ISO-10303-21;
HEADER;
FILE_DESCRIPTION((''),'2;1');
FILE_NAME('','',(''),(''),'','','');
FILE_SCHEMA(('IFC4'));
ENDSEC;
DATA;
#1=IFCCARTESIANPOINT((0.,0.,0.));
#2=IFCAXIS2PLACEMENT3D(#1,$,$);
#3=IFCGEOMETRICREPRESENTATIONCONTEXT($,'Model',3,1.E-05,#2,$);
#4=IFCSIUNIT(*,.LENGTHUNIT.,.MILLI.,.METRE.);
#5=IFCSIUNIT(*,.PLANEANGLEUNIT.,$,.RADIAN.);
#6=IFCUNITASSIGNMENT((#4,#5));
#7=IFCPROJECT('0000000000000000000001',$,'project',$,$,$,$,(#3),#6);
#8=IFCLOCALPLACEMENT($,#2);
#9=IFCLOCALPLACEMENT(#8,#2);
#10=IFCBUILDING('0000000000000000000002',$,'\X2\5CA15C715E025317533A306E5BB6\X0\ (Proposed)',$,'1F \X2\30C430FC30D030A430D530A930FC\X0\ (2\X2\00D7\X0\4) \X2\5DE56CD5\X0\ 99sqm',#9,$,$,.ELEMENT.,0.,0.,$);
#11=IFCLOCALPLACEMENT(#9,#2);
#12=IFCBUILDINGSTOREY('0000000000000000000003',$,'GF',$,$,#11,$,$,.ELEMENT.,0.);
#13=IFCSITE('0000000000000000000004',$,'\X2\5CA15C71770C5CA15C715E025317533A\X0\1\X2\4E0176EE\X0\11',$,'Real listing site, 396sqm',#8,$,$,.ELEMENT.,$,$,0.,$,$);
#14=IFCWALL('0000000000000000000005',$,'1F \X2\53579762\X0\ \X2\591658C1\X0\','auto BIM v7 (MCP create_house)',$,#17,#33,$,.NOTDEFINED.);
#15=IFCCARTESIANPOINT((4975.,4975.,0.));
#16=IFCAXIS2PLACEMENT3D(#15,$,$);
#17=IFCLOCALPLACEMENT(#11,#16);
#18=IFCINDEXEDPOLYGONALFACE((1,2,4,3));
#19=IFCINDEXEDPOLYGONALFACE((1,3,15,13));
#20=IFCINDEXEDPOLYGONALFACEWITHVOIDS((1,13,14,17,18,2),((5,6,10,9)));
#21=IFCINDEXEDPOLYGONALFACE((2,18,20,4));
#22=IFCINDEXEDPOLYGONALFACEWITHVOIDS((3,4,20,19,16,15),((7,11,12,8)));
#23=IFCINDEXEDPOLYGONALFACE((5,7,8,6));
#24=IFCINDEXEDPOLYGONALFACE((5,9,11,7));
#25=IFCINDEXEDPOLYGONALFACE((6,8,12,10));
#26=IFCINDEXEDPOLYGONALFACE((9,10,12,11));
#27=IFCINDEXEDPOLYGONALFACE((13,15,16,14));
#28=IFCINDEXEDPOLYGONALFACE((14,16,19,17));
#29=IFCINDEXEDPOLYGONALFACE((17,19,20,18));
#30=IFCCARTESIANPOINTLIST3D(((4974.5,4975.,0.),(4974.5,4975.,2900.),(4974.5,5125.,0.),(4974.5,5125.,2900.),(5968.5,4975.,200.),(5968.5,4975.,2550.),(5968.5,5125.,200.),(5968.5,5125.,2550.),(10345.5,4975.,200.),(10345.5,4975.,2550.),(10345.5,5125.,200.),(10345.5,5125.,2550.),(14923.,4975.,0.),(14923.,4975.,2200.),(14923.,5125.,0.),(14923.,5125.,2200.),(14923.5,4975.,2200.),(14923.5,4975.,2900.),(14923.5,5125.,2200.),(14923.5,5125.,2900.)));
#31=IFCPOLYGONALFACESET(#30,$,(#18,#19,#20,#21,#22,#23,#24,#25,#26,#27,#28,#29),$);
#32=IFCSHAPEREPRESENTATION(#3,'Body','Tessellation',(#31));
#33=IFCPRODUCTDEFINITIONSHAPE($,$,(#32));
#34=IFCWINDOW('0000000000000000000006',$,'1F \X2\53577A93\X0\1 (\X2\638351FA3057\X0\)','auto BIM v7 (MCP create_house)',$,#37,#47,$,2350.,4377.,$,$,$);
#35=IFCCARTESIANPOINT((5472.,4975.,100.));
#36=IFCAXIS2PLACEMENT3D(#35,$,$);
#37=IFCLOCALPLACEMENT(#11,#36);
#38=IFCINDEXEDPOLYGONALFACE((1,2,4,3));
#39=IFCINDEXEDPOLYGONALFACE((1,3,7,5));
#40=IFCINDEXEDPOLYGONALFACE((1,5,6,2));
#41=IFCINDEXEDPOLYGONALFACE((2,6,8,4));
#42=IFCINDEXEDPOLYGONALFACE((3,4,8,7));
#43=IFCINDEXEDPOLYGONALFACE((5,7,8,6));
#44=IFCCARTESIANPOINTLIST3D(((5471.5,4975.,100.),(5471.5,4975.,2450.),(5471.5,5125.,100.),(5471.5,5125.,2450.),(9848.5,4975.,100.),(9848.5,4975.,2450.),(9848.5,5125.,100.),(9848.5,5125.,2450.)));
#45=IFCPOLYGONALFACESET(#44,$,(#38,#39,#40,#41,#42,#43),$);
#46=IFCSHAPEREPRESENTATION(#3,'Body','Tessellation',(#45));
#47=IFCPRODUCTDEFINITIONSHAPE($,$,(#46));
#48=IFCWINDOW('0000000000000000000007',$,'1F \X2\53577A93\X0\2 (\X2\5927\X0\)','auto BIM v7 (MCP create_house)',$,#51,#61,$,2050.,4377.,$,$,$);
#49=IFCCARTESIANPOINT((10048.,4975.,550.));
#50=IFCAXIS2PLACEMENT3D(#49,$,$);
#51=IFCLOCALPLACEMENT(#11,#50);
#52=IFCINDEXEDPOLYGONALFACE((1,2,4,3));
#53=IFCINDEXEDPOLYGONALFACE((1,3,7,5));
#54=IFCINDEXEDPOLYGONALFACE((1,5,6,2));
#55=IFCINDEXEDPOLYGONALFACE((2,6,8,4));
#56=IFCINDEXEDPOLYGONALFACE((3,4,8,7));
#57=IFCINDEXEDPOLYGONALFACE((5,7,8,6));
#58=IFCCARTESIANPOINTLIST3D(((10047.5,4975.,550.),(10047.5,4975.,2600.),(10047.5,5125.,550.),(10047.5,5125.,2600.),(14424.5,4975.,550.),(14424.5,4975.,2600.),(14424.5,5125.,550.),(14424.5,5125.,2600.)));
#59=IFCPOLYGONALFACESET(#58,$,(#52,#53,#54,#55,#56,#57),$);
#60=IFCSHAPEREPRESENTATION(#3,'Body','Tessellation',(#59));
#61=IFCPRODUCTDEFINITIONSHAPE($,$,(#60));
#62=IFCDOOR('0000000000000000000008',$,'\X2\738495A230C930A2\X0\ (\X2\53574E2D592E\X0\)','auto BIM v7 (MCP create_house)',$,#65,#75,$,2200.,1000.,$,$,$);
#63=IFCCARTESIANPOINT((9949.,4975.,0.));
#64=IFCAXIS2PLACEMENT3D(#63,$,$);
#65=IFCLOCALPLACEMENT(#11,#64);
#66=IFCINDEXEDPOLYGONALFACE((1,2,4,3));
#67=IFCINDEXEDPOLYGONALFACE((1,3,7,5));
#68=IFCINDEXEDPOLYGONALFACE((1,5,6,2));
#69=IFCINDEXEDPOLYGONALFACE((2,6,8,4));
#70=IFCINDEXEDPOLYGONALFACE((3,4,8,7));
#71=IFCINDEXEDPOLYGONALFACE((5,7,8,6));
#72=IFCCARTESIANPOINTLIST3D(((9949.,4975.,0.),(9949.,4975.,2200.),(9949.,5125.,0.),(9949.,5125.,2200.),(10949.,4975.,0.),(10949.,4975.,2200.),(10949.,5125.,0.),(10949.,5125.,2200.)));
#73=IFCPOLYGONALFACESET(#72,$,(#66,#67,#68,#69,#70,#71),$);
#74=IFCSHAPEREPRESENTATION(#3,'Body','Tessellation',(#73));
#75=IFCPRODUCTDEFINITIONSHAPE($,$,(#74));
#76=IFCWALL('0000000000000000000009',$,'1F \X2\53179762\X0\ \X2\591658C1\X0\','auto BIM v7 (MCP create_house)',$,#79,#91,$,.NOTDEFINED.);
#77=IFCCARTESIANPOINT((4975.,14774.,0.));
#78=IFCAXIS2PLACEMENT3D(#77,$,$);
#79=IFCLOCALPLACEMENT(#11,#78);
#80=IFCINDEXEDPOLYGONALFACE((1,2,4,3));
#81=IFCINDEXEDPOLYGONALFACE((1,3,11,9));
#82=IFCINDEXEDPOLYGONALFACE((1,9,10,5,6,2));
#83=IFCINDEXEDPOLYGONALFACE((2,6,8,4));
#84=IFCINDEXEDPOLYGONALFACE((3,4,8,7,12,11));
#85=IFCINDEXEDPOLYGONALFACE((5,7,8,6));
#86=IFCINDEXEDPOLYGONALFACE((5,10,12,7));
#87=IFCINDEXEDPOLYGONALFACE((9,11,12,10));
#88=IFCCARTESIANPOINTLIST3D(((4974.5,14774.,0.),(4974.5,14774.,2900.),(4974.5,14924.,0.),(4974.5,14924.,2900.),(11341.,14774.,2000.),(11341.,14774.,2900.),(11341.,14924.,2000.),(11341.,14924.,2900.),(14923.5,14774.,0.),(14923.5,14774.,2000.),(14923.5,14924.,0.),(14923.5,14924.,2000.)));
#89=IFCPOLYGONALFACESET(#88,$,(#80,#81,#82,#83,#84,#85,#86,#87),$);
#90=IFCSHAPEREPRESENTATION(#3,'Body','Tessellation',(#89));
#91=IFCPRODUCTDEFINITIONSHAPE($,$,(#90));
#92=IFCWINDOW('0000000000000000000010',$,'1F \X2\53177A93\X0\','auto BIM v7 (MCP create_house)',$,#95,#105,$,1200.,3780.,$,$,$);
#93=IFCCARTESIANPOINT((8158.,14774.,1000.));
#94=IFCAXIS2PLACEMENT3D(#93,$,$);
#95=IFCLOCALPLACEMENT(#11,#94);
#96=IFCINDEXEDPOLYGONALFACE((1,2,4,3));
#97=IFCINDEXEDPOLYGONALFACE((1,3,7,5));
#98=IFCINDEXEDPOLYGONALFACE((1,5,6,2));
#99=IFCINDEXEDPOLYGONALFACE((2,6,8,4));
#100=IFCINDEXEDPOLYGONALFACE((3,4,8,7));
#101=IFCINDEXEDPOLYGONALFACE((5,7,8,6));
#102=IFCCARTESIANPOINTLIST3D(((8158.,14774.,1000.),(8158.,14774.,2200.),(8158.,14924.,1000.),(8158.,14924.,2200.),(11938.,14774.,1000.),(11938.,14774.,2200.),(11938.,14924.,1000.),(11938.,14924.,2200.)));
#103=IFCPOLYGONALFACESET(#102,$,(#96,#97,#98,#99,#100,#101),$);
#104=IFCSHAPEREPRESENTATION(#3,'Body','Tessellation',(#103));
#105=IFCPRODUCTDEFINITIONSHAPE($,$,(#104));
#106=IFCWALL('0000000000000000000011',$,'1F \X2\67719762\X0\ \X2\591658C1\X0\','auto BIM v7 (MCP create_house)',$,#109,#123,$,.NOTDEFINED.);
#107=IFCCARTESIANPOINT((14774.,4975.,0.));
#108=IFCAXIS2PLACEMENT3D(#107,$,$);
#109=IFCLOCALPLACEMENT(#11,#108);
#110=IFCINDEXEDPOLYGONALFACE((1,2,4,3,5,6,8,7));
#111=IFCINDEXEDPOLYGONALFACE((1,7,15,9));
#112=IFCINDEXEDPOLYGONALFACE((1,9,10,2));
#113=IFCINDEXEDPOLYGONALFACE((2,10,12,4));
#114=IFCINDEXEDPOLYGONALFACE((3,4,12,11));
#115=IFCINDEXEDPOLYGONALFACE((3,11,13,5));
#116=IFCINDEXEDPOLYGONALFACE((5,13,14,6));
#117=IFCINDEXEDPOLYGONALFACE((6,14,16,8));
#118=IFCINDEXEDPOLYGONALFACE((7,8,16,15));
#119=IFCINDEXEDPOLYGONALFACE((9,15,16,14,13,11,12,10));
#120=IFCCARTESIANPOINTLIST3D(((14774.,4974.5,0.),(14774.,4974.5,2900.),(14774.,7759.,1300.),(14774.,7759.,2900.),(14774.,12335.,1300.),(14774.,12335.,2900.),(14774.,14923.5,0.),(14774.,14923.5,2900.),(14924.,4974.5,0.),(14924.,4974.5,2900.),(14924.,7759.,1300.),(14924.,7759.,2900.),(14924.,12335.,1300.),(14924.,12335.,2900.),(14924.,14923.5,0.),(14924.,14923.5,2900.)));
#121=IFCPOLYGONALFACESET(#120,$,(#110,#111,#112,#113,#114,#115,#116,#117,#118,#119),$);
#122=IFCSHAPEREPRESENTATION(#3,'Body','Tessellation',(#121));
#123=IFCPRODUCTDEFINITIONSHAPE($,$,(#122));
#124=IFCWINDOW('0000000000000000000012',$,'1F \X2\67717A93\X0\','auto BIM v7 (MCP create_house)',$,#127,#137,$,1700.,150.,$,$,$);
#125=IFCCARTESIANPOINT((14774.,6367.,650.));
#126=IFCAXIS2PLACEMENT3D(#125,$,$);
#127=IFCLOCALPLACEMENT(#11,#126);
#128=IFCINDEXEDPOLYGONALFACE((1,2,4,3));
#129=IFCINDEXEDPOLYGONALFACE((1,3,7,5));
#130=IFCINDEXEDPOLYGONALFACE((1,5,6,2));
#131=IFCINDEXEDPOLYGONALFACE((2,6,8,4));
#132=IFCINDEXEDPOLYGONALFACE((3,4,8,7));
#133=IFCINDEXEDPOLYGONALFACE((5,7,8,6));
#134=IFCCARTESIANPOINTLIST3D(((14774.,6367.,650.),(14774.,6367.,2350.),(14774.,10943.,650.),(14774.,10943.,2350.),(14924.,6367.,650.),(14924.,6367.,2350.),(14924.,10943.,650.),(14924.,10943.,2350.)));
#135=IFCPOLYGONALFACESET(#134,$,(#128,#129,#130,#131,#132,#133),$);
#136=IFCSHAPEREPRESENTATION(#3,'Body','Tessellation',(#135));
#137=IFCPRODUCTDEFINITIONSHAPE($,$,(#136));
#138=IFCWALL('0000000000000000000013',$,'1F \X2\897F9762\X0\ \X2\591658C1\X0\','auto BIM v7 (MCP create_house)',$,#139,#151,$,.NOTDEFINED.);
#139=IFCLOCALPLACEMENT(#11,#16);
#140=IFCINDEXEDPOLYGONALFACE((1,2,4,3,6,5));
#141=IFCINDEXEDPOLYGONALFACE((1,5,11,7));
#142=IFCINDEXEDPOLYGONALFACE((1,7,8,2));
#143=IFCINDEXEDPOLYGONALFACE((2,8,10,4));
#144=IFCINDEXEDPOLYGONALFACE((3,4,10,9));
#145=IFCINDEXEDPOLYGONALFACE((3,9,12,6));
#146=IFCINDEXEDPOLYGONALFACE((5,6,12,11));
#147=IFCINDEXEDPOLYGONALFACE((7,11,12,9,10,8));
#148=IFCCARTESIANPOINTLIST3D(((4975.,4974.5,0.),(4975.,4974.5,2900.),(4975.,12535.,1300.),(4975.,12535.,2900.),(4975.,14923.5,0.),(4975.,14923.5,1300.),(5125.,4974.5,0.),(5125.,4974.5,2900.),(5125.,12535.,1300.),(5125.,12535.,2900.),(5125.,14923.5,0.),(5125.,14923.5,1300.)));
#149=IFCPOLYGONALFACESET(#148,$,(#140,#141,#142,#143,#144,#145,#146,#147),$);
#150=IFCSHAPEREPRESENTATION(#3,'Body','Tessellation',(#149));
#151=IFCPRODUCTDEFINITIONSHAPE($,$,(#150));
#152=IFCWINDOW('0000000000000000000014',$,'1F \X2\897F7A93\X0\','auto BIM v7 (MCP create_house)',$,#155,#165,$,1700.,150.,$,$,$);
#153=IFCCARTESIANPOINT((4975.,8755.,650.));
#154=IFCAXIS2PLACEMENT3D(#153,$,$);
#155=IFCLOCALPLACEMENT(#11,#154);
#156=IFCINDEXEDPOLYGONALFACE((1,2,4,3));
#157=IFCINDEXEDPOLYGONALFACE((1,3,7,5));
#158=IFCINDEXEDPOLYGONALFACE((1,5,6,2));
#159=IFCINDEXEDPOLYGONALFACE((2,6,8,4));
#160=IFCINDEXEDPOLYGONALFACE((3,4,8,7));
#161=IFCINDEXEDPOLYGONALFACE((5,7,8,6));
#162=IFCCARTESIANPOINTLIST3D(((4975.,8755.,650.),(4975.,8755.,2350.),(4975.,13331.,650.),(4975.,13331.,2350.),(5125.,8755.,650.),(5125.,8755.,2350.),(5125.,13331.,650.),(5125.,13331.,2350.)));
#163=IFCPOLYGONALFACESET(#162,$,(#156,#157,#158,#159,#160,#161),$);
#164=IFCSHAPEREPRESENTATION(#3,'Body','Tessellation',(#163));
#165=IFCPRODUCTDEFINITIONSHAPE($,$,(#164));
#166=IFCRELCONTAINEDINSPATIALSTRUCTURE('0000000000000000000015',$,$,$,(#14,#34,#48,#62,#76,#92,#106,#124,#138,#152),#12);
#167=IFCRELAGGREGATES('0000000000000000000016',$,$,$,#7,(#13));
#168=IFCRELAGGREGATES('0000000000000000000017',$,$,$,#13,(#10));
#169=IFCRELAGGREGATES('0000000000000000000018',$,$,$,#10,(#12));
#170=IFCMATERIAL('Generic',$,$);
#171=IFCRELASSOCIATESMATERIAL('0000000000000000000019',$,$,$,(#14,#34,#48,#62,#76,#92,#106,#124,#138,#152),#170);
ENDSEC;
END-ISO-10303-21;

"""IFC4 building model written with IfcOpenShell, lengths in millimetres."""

from ifc_helpers import new_model, si_unit, frame, frame_2d, origin, place, context, project, spatial, rectangle, extrude, material, element, fill, save


model = new_model("IFC4")

# Units and contexts
model_context = context("Model", 3, precision=1e-05, world=origin())
ifc_project = project(units=[si_unit("LENGTHUNIT", "METRE", prefix="MILLI"), si_unit("PLANEANGLEUNIT", "RADIAN")], contexts=[model_context])

# Site, building, storey
site_placement = place(None, origin())
site = spatial("IfcSite", under=ifc_project, at=site_placement, Name="岡山県岡山市北区1丁目11", ObjectType="Real listing site, 396sqm", CompositionType="ELEMENT", RefElevation=0.0)
building_placement = place(site_placement, origin())
building = spatial("IfcBuilding", under=site, at=building_placement, Name="岡山市北区の家 (Proposed)", ObjectType="1F ツーバイフォー (2×4) 工法 99sqm", CompositionType="ELEMENT", ElevationOfRefHeight=0.0, ElevationOfTerrain=0.0)
storey_placement = place(building_placement, origin())
storey = spatial("IfcBuildingStorey", under=building, at=storey_placement, Name="GF", CompositionType="ELEMENT", Elevation=0.0)

# Shared definitions
ifc_material = material(Name="Generic")

# Wall, openings, windows, door
wall_1_placement = place(storey_placement, frame((4975.0, 4975.0, 0.0)))
wall_1 = element("IfcWall", 1, at=wall_1_placement, inside=storey, material=ifc_material, Name="1F 南面 外壁", Description="auto BIM v7 (MCP create_house)", PredefinedType="NOTDEFINED", context=model_context, shape_type="SweptSolid", body=[
    extrude(rectangle(XDim=9949.0, YDim=150.0, at=frame_2d((4974.0, 75.0))), frame((4975.0, 4975.0, 0.0)), (0.0, 0.0, 1.0), 2900.0),
])
opening_1_placement = place(storey_placement, frame((5472.0, 4975.0, 100.0)))
opening_1 = element("IfcOpeningElement", 2, at=opening_1_placement, cuts=wall_1, PredefinedType="NOTDEFINED", context=model_context, shape_type="SweptSolid", body=[
    extrude(rectangle(XDim=4377.0, YDim=150.0, at=frame_2d((2188.0, 75.0))), frame((5472.0, 4975.0, 100.0)), (0.0, 0.0, 1.0), 2350.0),
])
opening_2_placement = place(storey_placement, frame((10048.0, 4975.0, 550.0)))
opening_2 = element("IfcOpeningElement", 3, at=opening_2_placement, cuts=wall_1, PredefinedType="NOTDEFINED", context=model_context, shape_type="SweptSolid", body=[
    extrude(rectangle(XDim=4377.0, YDim=150.0, at=frame_2d((2188.0, 75.0))), frame((10048.0, 4975.0, 550.0)), (0.0, 0.0, 1.0), 2050.0),
])
opening_3_placement = place(storey_placement, frame((9949.0, 4975.0, 0.0)))
opening_3 = element("IfcOpeningElement", 4, at=opening_3_placement, cuts=wall_1, PredefinedType="NOTDEFINED", context=model_context, shape_type="SweptSolid", body=[
    extrude(rectangle(XDim=1000.0, YDim=150.0, at=frame_2d((500.0, 75.0))), frame((9949.0, 4975.0, 0.0)), (0.0, 0.0, 1.0), 2200.0),
])
window_1_placement = place(storey_placement, frame((5472.0, 4975.0, 100.0)))
window_1 = element("IfcWindow", 5, at=window_1_placement, inside=storey, material=ifc_material, Name="1F 南窓1 (掃出し)", Description="auto BIM v7 (MCP create_house)", OverallHeight=2350.0, OverallWidth=4377.0, context=model_context, shape_type="SweptSolid", body=[
    extrude(rectangle(XDim=4377.0, YDim=150.0, at=frame_2d((2188.0, 75.0))), frame((5472.0, 4975.0, 100.0)), (0.0, 0.0, 1.0), 2350.0),
])
fill(opening_1, window_1)
window_2_placement = place(storey_placement, frame((10048.0, 4975.0, 550.0)))
window_2 = element("IfcWindow", 6, at=window_2_placement, inside=storey, material=ifc_material, Name="1F 南窓2 (大)", Description="auto BIM v7 (MCP create_house)", OverallHeight=2050.0, OverallWidth=4377.0, context=model_context, shape_type="SweptSolid", body=[
    extrude(rectangle(XDim=4377.0, YDim=150.0, at=frame_2d((2188.0, 75.0))), frame((10048.0, 4975.0, 550.0)), (0.0, 0.0, 1.0), 2050.0),
])
fill(opening_2, window_2)
door_placement = place(storey_placement, frame((9949.0, 4975.0, 0.0)))
door = element("IfcDoor", 7, at=door_placement, inside=storey, material=ifc_material, Name="玄関ドア (南中央)", Description="auto BIM v7 (MCP create_house)", OverallHeight=2200.0, OverallWidth=1000.0, context=model_context, shape_type="SweptSolid", body=[
    extrude(rectangle(XDim=1000.0, YDim=150.0, at=frame_2d((500.0, 75.0))), frame((9949.0, 4975.0, 0.0)), (0.0, 0.0, 1.0), 2200.0),
])
fill(opening_3, door)

# Walls, openings, windows
wall_2_placement = place(storey_placement, frame((4975.0, 14774.0, 0.0)))
wall_2 = element("IfcWall", 8, at=wall_2_placement, inside=storey, material=ifc_material, Name="1F 北面 外壁", Description="auto BIM v7 (MCP create_house)", PredefinedType="NOTDEFINED", context=model_context, shape_type="SweptSolid", body=[
    extrude(rectangle(XDim=9949.0, YDim=150.0, at=frame_2d((4974.0, 75.0))), frame((4975.0, 14774.0, 0.0)), (0.0, 0.0, 1.0), 2900.0),
])
opening_4_placement = place(storey_placement, frame((8158.0, 14774.0, 1000.0)))
opening_4 = element("IfcOpeningElement", 9, at=opening_4_placement, cuts=wall_2, PredefinedType="NOTDEFINED", context=model_context, shape_type="SweptSolid", body=[
    extrude(rectangle(XDim=3780.0, YDim=150.0, at=frame_2d((1890.0, 75.0))), frame((8158.0, 14774.0, 1000.0)), (0.0, 0.0, 1.0), 1200.0),
])
window_3_placement = place(storey_placement, frame((8158.0, 14774.0, 1000.0)))
window_3 = element("IfcWindow", 10, at=window_3_placement, inside=storey, material=ifc_material, Name="1F 北窓", Description="auto BIM v7 (MCP create_house)", OverallHeight=1200.0, OverallWidth=3780.0, context=model_context, shape_type="SweptSolid", body=[
    extrude(rectangle(XDim=3780.0, YDim=150.0, at=frame_2d((1890.0, 75.0))), frame((8158.0, 14774.0, 1000.0)), (0.0, 0.0, 1.0), 1200.0),
])
fill(opening_4, window_3)
wall_3_placement = place(storey_placement, frame((14774.0, 4975.0, 0.0)))
wall_3 = element("IfcWall", 11, at=wall_3_placement, inside=storey, material=ifc_material, Name="1F 東面 外壁", Description="auto BIM v7 (MCP create_house)", PredefinedType="NOTDEFINED", context=model_context, shape_type="SweptSolid", body=[
    extrude(rectangle(XDim=150.0, YDim=9949.0, at=frame_2d((75.0, 4974.0))), frame((14774.0, 4975.0, 0.0)), (0.0, 0.0, 1.0), 2900.0),
])
opening_5_placement = place(storey_placement, frame((14774.0, 6367.0, 650.0)))
opening_5 = element("IfcOpeningElement", 12, at=opening_5_placement, cuts=wall_3, PredefinedType="NOTDEFINED", context=model_context, shape_type="SweptSolid", body=[
    extrude(rectangle(XDim=150.0, YDim=4576.0, at=frame_2d((75.0, 2288.0))), frame((14774.0, 6367.0, 650.0)), (0.0, 0.0, 1.0), 1700.0),
])
window_4_placement = place(storey_placement, frame((14774.0, 6367.0, 650.0)))
window_4 = element("IfcWindow", 13, at=window_4_placement, inside=storey, material=ifc_material, Name="1F 東窓", Description="auto BIM v7 (MCP create_house)", OverallHeight=1700.0, OverallWidth=150.0, context=model_context, shape_type="SweptSolid", body=[
    extrude(rectangle(XDim=150.0, YDim=4576.0, at=frame_2d((75.0, 2288.0))), frame((14774.0, 6367.0, 650.0)), (0.0, 0.0, 1.0), 1700.0),
])
fill(opening_5, window_4)
wall_4_placement = place(storey_placement, frame((4975.0, 4975.0, 0.0)))
wall_4 = element("IfcWall", 14, at=wall_4_placement, inside=storey, material=ifc_material, Name="1F 西面 外壁", Description="auto BIM v7 (MCP create_house)", PredefinedType="NOTDEFINED", context=model_context, shape_type="SweptSolid", body=[
    extrude(rectangle(XDim=150.0, YDim=9949.0, at=frame_2d((75.0, 4974.0))), frame((4975.0, 4975.0, 0.0)), (0.0, 0.0, 1.0), 2900.0),
])
opening_6_placement = place(storey_placement, frame((4975.0, 8755.0, 650.0)))
opening_6 = element("IfcOpeningElement", 15, at=opening_6_placement, cuts=wall_4, PredefinedType="NOTDEFINED", context=model_context, shape_type="SweptSolid", body=[
    extrude(rectangle(XDim=150.0, YDim=4576.0, at=frame_2d((75.0, 2288.0))), frame((4975.0, 8755.0, 650.0)), (0.0, 0.0, 1.0), 1700.0),
])
window_5_placement = place(storey_placement, frame((4975.0, 8755.0, 650.0)))
window_5 = element("IfcWindow", 16, at=window_5_placement, inside=storey, material=ifc_material, Name="1F 西窓", Description="auto BIM v7 (MCP create_house)", OverallHeight=1700.0, OverallWidth=150.0, context=model_context, shape_type="SweptSolid", body=[
    extrude(rectangle(XDim=150.0, YDim=4576.0, at=frame_2d((75.0, 2288.0))), frame((4975.0, 8755.0, 650.0)), (0.0, 0.0, 1.0), 1700.0),
])
fill(opening_6, window_5)

save(model, "model.ifc")
